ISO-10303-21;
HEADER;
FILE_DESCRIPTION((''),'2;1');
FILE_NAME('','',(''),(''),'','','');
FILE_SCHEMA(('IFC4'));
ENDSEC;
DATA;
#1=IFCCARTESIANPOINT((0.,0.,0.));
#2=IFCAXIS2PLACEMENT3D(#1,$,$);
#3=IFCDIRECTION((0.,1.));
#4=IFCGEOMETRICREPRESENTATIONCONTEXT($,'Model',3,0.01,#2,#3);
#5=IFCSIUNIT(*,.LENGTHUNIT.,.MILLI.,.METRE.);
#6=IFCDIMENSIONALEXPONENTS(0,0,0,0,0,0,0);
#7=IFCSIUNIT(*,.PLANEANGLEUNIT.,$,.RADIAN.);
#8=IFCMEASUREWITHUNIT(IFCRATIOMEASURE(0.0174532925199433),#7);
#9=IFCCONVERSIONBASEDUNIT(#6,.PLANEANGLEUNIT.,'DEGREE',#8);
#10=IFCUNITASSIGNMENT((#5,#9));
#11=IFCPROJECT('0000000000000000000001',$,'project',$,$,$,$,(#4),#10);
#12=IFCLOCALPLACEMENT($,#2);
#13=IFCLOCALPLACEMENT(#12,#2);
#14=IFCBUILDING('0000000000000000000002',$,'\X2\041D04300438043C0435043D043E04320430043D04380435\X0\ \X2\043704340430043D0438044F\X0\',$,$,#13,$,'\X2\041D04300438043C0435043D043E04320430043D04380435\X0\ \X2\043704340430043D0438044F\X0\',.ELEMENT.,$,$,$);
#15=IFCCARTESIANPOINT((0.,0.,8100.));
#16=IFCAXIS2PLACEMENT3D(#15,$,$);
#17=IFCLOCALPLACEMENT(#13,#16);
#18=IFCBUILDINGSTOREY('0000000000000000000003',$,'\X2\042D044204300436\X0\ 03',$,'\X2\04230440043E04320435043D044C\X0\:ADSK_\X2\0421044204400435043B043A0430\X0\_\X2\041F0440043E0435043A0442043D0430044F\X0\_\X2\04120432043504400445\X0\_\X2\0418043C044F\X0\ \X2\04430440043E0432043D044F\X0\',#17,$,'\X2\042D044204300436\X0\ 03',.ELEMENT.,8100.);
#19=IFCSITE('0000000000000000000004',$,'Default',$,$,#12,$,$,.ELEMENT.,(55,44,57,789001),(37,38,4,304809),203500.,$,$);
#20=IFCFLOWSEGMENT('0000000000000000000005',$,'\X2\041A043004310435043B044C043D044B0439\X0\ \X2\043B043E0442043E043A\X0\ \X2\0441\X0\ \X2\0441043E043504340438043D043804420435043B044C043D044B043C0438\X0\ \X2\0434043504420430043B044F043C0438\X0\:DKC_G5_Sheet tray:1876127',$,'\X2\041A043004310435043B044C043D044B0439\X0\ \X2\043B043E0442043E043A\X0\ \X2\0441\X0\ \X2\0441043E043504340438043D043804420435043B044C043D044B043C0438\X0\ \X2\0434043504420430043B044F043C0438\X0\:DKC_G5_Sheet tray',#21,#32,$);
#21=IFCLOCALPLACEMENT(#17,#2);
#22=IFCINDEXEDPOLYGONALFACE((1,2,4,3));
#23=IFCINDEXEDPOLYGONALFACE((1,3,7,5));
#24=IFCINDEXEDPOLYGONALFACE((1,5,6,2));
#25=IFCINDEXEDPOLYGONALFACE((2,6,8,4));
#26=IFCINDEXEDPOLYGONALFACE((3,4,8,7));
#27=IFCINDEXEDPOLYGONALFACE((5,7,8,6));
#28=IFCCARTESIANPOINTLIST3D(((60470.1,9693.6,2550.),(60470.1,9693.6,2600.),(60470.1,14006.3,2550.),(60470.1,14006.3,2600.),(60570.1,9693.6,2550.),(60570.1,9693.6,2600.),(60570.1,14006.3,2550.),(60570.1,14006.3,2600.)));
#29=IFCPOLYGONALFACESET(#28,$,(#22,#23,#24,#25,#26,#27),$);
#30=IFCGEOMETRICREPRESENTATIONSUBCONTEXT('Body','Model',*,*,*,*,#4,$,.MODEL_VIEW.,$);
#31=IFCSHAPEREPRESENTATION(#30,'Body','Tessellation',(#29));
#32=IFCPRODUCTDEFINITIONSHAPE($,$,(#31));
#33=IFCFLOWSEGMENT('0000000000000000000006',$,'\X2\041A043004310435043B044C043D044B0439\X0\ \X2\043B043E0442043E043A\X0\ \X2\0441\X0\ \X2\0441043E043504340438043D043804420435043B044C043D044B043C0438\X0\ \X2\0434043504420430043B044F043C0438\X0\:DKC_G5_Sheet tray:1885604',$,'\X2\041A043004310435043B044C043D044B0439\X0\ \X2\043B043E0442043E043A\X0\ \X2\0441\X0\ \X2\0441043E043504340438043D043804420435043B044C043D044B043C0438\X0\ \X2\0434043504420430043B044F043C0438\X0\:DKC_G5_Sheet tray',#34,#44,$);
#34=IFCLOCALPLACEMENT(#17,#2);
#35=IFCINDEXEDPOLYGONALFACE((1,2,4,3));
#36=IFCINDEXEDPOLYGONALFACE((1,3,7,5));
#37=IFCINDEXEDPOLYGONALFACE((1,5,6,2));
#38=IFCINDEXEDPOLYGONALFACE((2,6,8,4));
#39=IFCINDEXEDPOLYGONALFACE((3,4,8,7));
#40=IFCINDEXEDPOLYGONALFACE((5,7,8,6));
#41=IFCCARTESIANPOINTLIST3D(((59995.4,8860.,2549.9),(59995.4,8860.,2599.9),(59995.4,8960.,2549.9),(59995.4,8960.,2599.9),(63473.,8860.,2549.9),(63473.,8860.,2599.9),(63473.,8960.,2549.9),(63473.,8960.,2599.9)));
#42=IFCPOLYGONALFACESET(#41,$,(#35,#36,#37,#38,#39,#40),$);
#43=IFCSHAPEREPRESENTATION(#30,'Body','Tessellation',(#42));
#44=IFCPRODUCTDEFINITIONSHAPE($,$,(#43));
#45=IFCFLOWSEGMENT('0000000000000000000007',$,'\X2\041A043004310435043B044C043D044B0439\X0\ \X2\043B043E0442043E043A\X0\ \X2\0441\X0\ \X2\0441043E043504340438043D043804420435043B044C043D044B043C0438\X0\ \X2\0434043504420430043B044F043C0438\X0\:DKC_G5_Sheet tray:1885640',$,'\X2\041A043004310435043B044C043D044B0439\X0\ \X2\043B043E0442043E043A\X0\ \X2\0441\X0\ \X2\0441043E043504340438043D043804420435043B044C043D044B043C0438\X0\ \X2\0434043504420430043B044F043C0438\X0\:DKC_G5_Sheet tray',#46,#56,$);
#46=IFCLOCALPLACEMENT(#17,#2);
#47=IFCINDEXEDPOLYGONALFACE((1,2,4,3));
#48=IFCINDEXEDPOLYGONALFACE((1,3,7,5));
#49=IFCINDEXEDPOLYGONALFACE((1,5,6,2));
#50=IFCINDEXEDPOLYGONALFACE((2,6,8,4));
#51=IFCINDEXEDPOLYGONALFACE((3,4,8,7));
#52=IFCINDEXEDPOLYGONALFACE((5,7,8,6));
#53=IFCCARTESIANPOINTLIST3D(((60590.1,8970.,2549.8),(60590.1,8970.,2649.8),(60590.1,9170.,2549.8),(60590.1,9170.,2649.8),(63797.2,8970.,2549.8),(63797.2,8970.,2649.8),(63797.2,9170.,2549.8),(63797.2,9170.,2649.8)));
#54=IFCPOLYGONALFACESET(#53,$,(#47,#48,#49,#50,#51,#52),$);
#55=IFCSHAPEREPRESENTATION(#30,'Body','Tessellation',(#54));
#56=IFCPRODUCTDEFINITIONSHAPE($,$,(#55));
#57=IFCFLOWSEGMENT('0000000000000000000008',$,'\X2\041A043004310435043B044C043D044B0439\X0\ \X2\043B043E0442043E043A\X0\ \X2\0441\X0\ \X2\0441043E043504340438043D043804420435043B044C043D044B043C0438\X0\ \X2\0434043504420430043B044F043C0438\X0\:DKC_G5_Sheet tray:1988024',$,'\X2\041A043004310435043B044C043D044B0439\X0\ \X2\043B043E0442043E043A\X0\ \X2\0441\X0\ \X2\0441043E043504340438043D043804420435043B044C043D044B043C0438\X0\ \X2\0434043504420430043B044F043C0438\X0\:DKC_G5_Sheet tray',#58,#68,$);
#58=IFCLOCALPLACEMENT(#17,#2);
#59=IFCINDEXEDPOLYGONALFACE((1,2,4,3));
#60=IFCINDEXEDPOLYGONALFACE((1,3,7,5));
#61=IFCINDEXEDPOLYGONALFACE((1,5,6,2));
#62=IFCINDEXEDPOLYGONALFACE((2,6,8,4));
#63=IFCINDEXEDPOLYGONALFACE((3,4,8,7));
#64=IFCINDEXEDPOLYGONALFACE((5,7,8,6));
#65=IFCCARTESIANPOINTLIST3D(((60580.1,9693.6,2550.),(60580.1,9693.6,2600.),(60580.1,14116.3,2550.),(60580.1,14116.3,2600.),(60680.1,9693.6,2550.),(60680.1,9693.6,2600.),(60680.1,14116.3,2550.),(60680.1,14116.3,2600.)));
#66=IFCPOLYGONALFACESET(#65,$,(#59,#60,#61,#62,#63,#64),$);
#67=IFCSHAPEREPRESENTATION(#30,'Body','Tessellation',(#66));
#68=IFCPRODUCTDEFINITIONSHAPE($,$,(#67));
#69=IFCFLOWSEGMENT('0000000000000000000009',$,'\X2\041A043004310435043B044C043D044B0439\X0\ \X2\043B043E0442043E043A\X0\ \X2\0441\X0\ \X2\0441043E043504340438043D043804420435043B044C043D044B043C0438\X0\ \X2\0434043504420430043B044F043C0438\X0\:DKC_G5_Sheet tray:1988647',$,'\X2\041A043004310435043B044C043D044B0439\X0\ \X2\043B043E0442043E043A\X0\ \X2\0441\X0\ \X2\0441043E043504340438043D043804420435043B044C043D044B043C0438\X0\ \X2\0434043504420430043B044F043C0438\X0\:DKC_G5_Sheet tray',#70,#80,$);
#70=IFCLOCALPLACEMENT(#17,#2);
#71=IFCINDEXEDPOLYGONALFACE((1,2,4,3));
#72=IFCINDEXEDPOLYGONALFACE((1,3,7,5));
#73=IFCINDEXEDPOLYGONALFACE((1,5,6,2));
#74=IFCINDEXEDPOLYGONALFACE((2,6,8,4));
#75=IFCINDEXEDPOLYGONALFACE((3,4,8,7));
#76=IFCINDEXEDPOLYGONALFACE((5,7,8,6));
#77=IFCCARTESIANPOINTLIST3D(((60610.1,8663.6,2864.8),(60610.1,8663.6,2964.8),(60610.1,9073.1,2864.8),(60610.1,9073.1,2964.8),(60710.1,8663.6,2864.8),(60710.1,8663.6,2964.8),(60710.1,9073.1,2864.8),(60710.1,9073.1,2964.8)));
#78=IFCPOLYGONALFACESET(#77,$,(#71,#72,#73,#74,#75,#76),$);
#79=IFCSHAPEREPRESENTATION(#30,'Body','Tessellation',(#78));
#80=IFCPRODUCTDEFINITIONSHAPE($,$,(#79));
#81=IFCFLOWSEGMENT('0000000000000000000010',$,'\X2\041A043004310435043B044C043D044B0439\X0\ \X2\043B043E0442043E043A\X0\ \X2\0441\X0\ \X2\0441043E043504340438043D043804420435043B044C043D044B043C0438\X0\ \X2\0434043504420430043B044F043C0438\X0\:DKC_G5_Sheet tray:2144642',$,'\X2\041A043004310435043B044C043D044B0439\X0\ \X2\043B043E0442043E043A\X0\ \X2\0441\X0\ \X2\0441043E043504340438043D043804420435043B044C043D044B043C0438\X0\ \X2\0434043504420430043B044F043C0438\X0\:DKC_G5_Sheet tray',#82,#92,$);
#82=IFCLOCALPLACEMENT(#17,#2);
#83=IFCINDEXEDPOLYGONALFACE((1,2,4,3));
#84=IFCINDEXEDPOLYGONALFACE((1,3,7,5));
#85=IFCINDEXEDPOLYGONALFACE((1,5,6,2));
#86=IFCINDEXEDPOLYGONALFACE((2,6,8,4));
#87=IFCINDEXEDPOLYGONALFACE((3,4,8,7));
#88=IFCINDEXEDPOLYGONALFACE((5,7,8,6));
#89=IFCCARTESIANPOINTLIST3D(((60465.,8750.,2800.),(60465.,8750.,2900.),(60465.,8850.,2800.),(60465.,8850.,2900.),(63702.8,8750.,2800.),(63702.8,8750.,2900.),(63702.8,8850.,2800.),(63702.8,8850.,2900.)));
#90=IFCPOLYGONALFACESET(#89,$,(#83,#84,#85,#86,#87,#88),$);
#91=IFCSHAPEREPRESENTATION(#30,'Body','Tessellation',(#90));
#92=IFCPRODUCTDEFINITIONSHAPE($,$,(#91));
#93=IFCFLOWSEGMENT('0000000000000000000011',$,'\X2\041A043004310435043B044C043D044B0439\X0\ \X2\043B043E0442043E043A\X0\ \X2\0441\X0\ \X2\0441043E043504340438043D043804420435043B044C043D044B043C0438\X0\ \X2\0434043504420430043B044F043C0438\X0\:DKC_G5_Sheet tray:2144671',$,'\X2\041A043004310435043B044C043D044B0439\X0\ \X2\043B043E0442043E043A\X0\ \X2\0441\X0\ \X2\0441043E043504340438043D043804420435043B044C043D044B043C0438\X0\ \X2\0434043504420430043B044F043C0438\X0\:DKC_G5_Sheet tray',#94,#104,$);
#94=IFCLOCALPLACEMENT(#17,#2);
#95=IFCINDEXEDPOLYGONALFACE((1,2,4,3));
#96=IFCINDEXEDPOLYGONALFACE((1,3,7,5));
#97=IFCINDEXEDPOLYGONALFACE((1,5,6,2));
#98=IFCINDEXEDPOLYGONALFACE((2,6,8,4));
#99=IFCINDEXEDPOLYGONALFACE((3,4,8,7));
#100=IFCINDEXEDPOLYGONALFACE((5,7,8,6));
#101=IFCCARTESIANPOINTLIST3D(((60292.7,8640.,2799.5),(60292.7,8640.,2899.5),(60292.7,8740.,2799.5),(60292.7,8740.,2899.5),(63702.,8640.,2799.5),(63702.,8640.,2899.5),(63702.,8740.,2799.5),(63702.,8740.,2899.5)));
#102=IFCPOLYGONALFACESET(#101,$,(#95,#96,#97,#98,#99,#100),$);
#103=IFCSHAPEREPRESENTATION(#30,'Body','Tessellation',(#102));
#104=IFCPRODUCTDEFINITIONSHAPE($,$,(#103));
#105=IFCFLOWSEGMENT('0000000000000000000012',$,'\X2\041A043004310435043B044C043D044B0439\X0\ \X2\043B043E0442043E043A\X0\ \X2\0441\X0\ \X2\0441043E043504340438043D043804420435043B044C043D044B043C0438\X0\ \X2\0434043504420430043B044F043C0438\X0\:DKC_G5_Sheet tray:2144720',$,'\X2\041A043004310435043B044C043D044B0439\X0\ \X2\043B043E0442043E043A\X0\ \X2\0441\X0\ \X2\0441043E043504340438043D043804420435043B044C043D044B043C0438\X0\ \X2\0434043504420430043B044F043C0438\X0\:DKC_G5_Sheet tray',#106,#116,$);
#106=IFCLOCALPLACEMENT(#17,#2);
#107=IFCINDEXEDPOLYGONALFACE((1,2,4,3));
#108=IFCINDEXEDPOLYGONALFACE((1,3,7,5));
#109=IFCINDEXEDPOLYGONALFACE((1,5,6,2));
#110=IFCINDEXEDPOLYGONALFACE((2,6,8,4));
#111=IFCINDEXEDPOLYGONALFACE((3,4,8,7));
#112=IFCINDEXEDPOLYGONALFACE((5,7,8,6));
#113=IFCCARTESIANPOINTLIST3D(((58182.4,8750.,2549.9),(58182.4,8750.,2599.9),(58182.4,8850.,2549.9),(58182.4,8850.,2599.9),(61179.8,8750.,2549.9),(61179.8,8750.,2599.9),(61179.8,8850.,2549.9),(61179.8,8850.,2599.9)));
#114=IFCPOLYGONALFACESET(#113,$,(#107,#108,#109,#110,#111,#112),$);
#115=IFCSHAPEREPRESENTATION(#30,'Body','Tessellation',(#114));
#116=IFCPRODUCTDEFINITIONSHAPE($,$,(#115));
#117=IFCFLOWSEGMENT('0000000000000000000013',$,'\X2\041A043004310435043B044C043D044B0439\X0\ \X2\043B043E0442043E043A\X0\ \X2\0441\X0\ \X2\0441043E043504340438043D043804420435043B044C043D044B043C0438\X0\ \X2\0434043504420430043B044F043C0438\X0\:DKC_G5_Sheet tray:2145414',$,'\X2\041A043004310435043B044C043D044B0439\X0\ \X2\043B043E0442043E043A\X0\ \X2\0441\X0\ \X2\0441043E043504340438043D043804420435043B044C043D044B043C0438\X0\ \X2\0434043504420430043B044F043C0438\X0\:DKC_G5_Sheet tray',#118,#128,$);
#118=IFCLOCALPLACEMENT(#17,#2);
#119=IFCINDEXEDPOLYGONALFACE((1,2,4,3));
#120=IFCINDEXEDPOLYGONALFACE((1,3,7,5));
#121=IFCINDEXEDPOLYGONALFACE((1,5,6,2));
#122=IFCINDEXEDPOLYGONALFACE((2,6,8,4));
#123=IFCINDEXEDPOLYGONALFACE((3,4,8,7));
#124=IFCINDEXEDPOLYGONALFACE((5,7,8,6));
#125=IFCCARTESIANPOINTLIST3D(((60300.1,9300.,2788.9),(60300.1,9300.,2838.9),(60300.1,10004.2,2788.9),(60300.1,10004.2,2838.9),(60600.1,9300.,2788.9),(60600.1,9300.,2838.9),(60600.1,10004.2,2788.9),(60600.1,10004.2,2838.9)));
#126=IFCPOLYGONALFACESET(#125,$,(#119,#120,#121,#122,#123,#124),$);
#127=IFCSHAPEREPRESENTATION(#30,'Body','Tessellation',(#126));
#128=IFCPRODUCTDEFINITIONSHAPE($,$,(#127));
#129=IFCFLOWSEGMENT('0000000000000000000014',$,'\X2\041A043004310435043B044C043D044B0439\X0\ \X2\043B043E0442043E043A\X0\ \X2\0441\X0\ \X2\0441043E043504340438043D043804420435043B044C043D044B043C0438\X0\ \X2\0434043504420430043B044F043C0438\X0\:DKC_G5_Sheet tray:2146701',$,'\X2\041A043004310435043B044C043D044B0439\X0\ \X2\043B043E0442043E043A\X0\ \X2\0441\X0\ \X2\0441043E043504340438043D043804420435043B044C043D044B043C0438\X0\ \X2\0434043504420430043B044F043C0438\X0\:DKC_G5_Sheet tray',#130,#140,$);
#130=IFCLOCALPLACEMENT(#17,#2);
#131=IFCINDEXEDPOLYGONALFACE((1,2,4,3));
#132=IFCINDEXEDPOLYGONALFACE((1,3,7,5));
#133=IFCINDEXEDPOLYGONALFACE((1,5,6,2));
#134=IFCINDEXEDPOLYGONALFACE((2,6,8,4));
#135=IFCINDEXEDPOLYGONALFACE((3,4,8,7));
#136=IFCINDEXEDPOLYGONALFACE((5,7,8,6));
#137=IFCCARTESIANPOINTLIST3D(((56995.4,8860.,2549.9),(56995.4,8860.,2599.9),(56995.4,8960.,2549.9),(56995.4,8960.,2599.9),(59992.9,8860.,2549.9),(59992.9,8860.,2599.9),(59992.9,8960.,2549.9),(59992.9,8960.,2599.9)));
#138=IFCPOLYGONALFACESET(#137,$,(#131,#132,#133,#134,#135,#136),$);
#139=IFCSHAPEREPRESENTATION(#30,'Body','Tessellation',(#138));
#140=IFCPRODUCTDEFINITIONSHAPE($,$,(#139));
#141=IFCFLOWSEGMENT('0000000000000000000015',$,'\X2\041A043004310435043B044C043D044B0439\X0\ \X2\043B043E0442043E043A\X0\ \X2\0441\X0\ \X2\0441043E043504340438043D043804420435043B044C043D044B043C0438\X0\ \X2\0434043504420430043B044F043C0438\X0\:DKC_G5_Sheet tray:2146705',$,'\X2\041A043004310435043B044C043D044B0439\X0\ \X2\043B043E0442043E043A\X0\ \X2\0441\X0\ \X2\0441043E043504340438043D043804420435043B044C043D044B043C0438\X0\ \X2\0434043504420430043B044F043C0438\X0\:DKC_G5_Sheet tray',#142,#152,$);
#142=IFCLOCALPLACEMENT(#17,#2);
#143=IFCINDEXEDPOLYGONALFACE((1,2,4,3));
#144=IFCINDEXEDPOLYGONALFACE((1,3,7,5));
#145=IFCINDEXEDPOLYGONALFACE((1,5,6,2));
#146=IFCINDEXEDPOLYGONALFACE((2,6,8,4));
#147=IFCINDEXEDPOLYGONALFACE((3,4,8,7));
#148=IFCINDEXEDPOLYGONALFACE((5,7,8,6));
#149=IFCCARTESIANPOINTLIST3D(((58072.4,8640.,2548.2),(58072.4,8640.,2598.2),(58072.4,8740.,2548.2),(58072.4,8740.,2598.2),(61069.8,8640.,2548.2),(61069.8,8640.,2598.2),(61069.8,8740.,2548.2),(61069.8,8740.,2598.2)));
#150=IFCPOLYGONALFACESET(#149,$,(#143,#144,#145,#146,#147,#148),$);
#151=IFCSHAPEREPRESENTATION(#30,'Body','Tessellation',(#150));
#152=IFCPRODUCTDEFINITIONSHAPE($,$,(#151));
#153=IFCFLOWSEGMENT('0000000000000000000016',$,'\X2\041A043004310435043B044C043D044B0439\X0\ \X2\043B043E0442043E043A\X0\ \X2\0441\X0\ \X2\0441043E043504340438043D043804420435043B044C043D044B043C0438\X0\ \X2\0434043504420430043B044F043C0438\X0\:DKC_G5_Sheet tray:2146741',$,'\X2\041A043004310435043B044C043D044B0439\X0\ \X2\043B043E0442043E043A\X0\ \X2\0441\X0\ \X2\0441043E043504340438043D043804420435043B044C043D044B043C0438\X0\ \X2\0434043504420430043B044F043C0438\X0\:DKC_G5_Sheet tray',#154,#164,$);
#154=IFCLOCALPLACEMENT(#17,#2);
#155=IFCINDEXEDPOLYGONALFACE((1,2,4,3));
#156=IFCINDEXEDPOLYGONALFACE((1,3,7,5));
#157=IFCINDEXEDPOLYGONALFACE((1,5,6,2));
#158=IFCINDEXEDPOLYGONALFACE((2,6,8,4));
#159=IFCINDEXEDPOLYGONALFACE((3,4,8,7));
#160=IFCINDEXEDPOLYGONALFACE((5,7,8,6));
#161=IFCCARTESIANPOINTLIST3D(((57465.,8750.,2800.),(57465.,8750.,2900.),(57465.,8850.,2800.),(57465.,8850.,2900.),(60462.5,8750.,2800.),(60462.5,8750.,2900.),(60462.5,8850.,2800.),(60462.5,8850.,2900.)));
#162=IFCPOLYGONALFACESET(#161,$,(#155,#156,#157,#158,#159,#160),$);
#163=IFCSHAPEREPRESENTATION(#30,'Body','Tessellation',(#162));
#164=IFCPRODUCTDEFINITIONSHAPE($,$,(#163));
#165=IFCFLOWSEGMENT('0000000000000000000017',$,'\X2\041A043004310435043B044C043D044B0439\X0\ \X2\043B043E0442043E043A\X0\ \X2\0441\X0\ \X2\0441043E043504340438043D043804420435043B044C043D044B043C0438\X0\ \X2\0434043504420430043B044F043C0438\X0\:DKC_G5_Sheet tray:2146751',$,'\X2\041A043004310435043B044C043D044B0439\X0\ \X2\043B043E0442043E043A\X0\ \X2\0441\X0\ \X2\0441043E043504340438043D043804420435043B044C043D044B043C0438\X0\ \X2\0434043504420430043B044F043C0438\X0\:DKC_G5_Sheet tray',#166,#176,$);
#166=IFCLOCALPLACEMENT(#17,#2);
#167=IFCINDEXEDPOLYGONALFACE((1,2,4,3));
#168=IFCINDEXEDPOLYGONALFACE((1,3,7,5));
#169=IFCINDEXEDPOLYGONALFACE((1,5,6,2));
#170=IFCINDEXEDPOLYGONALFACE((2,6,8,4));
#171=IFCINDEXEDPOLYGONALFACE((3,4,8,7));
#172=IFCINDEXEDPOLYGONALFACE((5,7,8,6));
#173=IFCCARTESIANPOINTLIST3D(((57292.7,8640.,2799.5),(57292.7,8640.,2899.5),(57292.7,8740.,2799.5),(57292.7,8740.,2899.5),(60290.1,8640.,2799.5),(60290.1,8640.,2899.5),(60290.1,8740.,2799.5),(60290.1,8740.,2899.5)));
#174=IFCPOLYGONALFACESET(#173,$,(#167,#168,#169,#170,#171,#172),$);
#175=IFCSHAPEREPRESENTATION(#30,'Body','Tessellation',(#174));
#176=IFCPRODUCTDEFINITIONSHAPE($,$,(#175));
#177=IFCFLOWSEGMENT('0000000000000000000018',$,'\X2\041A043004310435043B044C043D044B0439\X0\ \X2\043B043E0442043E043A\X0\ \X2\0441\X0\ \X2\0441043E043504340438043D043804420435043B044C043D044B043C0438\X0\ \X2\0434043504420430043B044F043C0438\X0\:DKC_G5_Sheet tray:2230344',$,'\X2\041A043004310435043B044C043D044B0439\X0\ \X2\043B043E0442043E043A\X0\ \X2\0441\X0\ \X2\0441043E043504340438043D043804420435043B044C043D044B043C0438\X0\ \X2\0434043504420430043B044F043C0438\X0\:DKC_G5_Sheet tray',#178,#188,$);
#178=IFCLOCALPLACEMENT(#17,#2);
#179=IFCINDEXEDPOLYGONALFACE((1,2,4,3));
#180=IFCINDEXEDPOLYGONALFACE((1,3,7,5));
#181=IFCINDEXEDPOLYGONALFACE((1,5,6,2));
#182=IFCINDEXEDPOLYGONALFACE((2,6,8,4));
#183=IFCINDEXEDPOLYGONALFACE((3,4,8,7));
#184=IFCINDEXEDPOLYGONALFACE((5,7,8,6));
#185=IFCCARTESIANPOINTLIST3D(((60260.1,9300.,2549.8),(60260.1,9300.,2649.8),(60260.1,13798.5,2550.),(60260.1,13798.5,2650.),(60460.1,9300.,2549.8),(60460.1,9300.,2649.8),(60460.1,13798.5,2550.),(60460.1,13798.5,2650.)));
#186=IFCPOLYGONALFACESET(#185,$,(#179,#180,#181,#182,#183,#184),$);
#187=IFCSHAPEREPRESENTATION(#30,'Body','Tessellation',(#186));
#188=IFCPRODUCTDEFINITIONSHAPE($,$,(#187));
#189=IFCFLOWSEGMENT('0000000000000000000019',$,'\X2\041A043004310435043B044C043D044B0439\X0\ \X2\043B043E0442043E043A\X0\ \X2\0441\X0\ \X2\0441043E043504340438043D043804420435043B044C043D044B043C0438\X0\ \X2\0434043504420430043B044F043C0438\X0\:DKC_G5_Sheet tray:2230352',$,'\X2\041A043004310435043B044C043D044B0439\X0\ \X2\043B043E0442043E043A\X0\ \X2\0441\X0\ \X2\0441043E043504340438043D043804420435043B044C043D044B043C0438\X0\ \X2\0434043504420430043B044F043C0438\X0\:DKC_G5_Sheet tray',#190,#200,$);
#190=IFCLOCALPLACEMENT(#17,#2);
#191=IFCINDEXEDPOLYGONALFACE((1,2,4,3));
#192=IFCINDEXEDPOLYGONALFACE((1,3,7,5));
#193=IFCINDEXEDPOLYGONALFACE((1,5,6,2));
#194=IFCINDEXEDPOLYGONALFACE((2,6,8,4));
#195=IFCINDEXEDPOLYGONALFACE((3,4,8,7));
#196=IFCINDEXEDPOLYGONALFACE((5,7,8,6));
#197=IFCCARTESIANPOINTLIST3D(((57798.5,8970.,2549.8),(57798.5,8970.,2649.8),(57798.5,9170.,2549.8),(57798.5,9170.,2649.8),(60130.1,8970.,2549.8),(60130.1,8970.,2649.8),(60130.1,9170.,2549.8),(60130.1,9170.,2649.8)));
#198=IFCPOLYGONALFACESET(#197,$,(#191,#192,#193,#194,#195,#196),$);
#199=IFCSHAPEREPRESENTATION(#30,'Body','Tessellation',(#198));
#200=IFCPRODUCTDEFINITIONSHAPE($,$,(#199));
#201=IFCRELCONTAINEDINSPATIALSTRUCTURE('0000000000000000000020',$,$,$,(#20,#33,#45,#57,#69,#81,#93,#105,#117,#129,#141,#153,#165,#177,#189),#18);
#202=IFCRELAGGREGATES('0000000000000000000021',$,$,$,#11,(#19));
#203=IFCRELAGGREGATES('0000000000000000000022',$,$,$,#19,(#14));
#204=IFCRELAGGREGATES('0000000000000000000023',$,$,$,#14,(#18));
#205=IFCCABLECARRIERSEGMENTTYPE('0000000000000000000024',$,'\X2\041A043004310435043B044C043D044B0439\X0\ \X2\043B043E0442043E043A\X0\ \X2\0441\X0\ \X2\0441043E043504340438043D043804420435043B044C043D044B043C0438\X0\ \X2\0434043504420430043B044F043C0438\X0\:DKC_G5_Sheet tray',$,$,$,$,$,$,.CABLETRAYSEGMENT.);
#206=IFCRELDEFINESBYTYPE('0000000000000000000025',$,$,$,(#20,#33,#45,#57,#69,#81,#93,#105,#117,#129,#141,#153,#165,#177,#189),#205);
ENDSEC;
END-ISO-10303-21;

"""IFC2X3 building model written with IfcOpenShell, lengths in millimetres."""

from ifc_helpers import new_model, entity, si_unit, converted_unit, direction, frame, frame_2d, origin, origin_2d_with_axis, place, context, subcontext, project, spatial, rectangle, extrude, type_object, element, save


model = new_model("IFC2X3")

# Units and contexts
model_context = context("Model", 3, precision=0.01, world=origin(), true_north=direction((0.0, 1.0)))
body_context = subcontext(model_context, "Body", "Model", "MODEL_VIEW")
ifc_project = project(units=[si_unit("LENGTHUNIT", "METRE", prefix="MILLI"), converted_unit("PLANEANGLEUNIT", "DEGREE", entity("IfcRatioMeasure", 0.0174532925199433), si_unit("PLANEANGLEUNIT", "RADIAN"), dimensions=[0, 0, 0, 0, 0, 0, 0])], contexts=[model_context])

# Site, building, storey
site_placement = place(None, frame((0.0, 0.0, 0.0)))
site = spatial("IfcSite", under=ifc_project, at=site_placement, Name="Default", CompositionType="ELEMENT", RefLatitude=(55, 44, 57, 789001), RefLongitude=(37, 38, 4, 304809), RefElevation=203500.0)
building_placement = place(site_placement, origin())
building = spatial("IfcBuilding", under=site, at=building_placement, Name="Наименование здания", LongName="Наименование здания", CompositionType="ELEMENT")
storey_placement = place(building_placement, frame((0.0, 0.0, 8100.0)))
storey = spatial("IfcBuildingStorey", under=building, at=storey_placement, Name="Этаж 03", ObjectType="Уровень:ADSK_Стрелка_Проектная_Вверх_Имя уровня", LongName="Этаж 03", CompositionType="ELEMENT", Elevation=8100.0)

# Flow segments
cable_carrier_segment_type = type_object("IfcCableCarrierSegmentType", Name="Кабельный лоток с соединительными деталями:DKC_G5_Sheet tray", PredefinedType="CABLETRAYSEGMENT")
flow_segment_1_placement = place(storey_placement, frame((60470.1, 9693.6, 2550.0)))
element("IfcFlowSegment", 1, at=flow_segment_1_placement, inside=storey, type_object=cable_carrier_segment_type, Name="Кабельный лоток с соединительными деталями:DKC_G5_Sheet tray:1876127", ObjectType="Кабельный лоток с соединительными деталями:DKC_G5_Sheet tray", context=body_context, shape_type="SweptSolid", body=[
    extrude(rectangle(XDim=4312.7, YDim=100.0, at=frame_2d((0.0, 0.0), x_axis=(1.0, 0.0))), frame((50.0, 2156.3, 0.0), z_axis=(0.0, 0.0, 1.0), x_axis=(0.0, -1.0, 0.0)), (0.0, 0.0, 1.0), 50.0),
])
flow_segment_2_placement = place(storey_placement, frame((59995.4, 8860.0, 2549.9)))
element("IfcFlowSegment", 2, at=flow_segment_2_placement, inside=storey, type_object=cable_carrier_segment_type, Name="Кабельный лоток с соединительными деталями:DKC_G5_Sheet tray:1885604", ObjectType="Кабельный лоток с соединительными деталями:DKC_G5_Sheet tray", context=body_context, shape_type="SweptSolid", body=[
    extrude(rectangle(XDim=3477.6, YDim=100.0, at=frame_2d((0.0, 0.0), x_axis=(1.0, 0.0))), frame((1738.8, 50.0, 0.0), z_axis=(0.0, 0.0, 1.0), x_axis=(-1.0, 0.0, 0.0)), (0.0, 0.0, 1.0), 50.0),
])
flow_segment_3_placement = place(storey_placement, frame((60590.1, 8970.0, 2549.8)))
element("IfcFlowSegment", 3, at=flow_segment_3_placement, inside=storey, type_object=cable_carrier_segment_type, Name="Кабельный лоток с соединительными деталями:DKC_G5_Sheet tray:1885640", ObjectType="Кабельный лоток с соединительными деталями:DKC_G5_Sheet tray", context=body_context, shape_type="SweptSolid", body=[
    extrude(rectangle(XDim=3207.1, YDim=200.0, at=frame_2d((0.0, 0.0), x_axis=(1.0, 0.0))), frame((1603.5, 100.0, 0.0)), (0.0, 0.0, 1.0), 100.0),
])
flow_segment_4_placement = place(storey_placement, frame((60580.1, 9693.6, 2550.0)))
element("IfcFlowSegment", 4, at=flow_segment_4_placement, inside=storey, type_object=cable_carrier_segment_type, Name="Кабельный лоток с соединительными деталями:DKC_G5_Sheet tray:1988024", ObjectType="Кабельный лоток с соединительными деталями:DKC_G5_Sheet tray", context=body_context, shape_type="SweptSolid", body=[
    extrude(rectangle(XDim=4422.7, YDim=100.0, at=frame_2d((0.0, 0.0), x_axis=(1.0, 0.0))), frame((50.0, 2211.3, 0.0), z_axis=(0.0, 0.0, 1.0), x_axis=(0.0, -1.0, 0.0)), (0.0, 0.0, 1.0), 50.0),
])
flow_segment_5_placement = place(storey_placement, frame((60610.1, 8663.6, 2864.8)))
element("IfcFlowSegment", 5, at=flow_segment_5_placement, inside=storey, type_object=cable_carrier_segment_type, Name="Кабельный лоток с соединительными деталями:DKC_G5_Sheet tray:1988647", ObjectType="Кабельный лоток с соединительными деталями:DKC_G5_Sheet tray", context=body_context, shape_type="SweptSolid", body=[
    extrude(rectangle(XDim=409.5, YDim=100.0, at=frame_2d((0.0, 0.0), x_axis=(1.0, 0.0))), frame((50.0, 204.8, 0.0), z_axis=(0.0, 0.0, 1.0), x_axis=(0.0, -1.0, 0.0)), (0.0, 0.0, 1.0), 100.0),
])
flow_segment_6_placement = place(storey_placement, frame((60465.0, 8750.0, 2800.0)))
element("IfcFlowSegment", 6, at=flow_segment_6_placement, inside=storey, type_object=cable_carrier_segment_type, Name="Кабельный лоток с соединительными деталями:DKC_G5_Sheet tray:2144642", ObjectType="Кабельный лоток с соединительными деталями:DKC_G5_Sheet tray", context=body_context, shape_type="SweptSolid", body=[
    extrude(rectangle(XDim=3237.8, YDim=100.0, at=frame_2d((0.0, 0.0), x_axis=(1.0, 0.0))), frame((1618.9, 50.0, 0.0), z_axis=(0.000001, 0.000012, 1.0), x_axis=(-1.0, 0.0, 0.000001)), (0.0, 0.0, 1.0), 100.0),
])
flow_segment_7_placement = place(storey_placement, frame((60292.7, 8640.0, 2799.5)))
element("IfcFlowSegment", 7, at=flow_segment_7_placement, inside=storey, type_object=cable_carrier_segment_type, Name="Кабельный лоток с соединительными деталями:DKC_G5_Sheet tray:2144671", ObjectType="Кабельный лоток с соединительными деталями:DKC_G5_Sheet tray", context=body_context, shape_type="SweptSolid", body=[
    extrude(rectangle(XDim=3409.3, YDim=100.0, at=frame_2d((0.0, 0.0), x_axis=(1.0, 0.0))), frame((1704.6, 50.0, 0.0), z_axis=(0.0, -0.000024, 1.0), x_axis=(-1.0, 0.0, 0.0)), (0.0, 0.0, 1.0), 100.0),
])
flow_segment_8_placement = place(storey_placement, frame((58182.4, 8750.0, 2549.9)))
element("IfcFlowSegment", 8, at=flow_segment_8_placement, inside=storey, type_object=cable_carrier_segment_type, Name="Кабельный лоток с соединительными деталями:DKC_G5_Sheet tray:2144720", ObjectType="Кабельный лоток с соединительными деталями:DKC_G5_Sheet tray", context=body_context, shape_type="SweptSolid", body=[
    extrude(rectangle(XDim=2997.5, YDim=100.0, at=origin_2d_with_axis()), frame((1498.7, 50.0, 0.0)), (0.0, 0.0, 1.0), 50.0),
])
flow_segment_9_placement = place(storey_placement, frame((60300.1, 9300.0, 2788.9)))
element("IfcFlowSegment", 9, at=flow_segment_9_placement, inside=storey, type_object=cable_carrier_segment_type, Name="Кабельный лоток с соединительными деталями:DKC_G5_Sheet tray:2145414", ObjectType="Кабельный лоток с соединительными деталями:DKC_G5_Sheet tray", context=body_context, shape_type="SweptSolid", body=[
    extrude(rectangle(XDim=704.2, YDim=300.0, at=frame_2d((0.0, 0.0), x_axis=(1.0, 0.0))), frame((150.0, 352.1, 0.0), z_axis=(0.0, 0.0, 1.0), x_axis=(0.0, 1.0, 0.0)), (0.0, 0.0, 1.0), 50.0),
])
flow_segment_10_placement = place(storey_placement, frame((56995.4, 8860.0, 2549.9)))
element("IfcFlowSegment", 10, at=flow_segment_10_placement, inside=storey, type_object=cable_carrier_segment_type, Name="Кабельный лоток с соединительными деталями:DKC_G5_Sheet tray:2146701", ObjectType="Кабельный лоток с соединительными деталями:DKC_G5_Sheet tray", context=body_context, shape_type="SweptSolid", body=[
    extrude(rectangle(XDim=2997.5, YDim=100.0, at=frame_2d((0.0, 0.0), x_axis=(1.0, 0.0))), frame((1498.7, 50.0, 0.0), z_axis=(0.0, 0.0, 1.0), x_axis=(-1.0, 0.0, 0.0)), (0.0, 0.0, 1.0), 50.0),
])
flow_segment_11_placement = place(storey_placement, frame((58072.4, 8640.0, 2548.2)))
element("IfcFlowSegment", 11, at=flow_segment_11_placement, inside=storey, type_object=cable_carrier_segment_type, Name="Кабельный лоток с соединительными деталями:DKC_G5_Sheet tray:2146705", ObjectType="Кабельный лоток с соединительными деталями:DKC_G5_Sheet tray", context=body_context, shape_type="SweptSolid", body=[
    extrude(rectangle(XDim=2997.5, YDim=100.0, at=frame_2d((0.0, 0.0), x_axis=(1.0, 0.0))), frame((1498.7, 50.0, 0.0)), (0.0, 0.0, 1.0), 50.0),
])
flow_segment_12_placement = place(storey_placement, frame((57465.0, 8750.0, 2800.0)))
element("IfcFlowSegment", 12, at=flow_segment_12_placement, inside=storey, type_object=cable_carrier_segment_type, Name="Кабельный лоток с соединительными деталями:DKC_G5_Sheet tray:2146741", ObjectType="Кабельный лоток с соединительными деталями:DKC_G5_Sheet tray", context=body_context, shape_type="SweptSolid", body=[
    extrude(rectangle(XDim=2997.5, YDim=100.0, at=frame_2d((0.0, 0.0), x_axis=(1.0, 0.0))), frame((1498.7, 50.0, 0.0), z_axis=(0.000001, 0.0, 1.0), x_axis=(-1.0, 0.0, 0.000001)), (0.0, 0.0, 1.0), 100.0),
])
flow_segment_13_placement = place(storey_placement, frame((57292.7, 8640.0, 2799.5)))
element("IfcFlowSegment", 13, at=flow_segment_13_placement, inside=storey, type_object=cable_carrier_segment_type, Name="Кабельный лоток с соединительными деталями:DKC_G5_Sheet tray:2146751", ObjectType="Кабельный лоток с соединительными деталями:DKC_G5_Sheet tray", context=body_context, shape_type="SweptSolid", body=[
    extrude(rectangle(XDim=2997.5, YDim=100.0, at=origin_2d_with_axis()), frame((1498.7, 50.0, 0.0), z_axis=(0.0, 0.0, 1.0), x_axis=(-1.0, 0.0, 0.0)), (0.0, 0.0, 1.0), 100.0),
])
flow_segment_14_placement = place(storey_placement, frame((60260.1, 9300.0, 2549.8)))
element("IfcFlowSegment", 14, at=flow_segment_14_placement, inside=storey, type_object=cable_carrier_segment_type, Name="Кабельный лоток с соединительными деталями:DKC_G5_Sheet tray:2230344", ObjectType="Кабельный лоток с соединительными деталями:DKC_G5_Sheet tray", context=body_context, shape_type="SweptSolid", body=[
    extrude(rectangle(XDim=4498.5, YDim=200.0, at=frame_2d((0.0, 0.0), x_axis=(1.0, 0.0))), frame((100.0, 2249.3, 0.1), z_axis=(0.0, -0.000032, 1.0), x_axis=(0.0, 1.0, 0.000032)), (0.0, 0.0, 1.0), 100.0),
])
flow_segment_15_placement = place(storey_placement, frame((57798.5, 8970.0, 2549.8)))
element("IfcFlowSegment", 15, at=flow_segment_15_placement, inside=storey, type_object=cable_carrier_segment_type, Name="Кабельный лоток с соединительными деталями:DKC_G5_Sheet tray:2230352", ObjectType="Кабельный лоток с соединительными деталями:DKC_G5_Sheet tray", context=body_context, shape_type="SweptSolid", body=[
    extrude(rectangle(XDim=2331.7, YDim=200.0, at=origin_2d_with_axis()), frame((1165.8, 100.0, 0.0)), (0.0, 0.0, 1.0), 100.0),
])

save(model, "model.ifc")
